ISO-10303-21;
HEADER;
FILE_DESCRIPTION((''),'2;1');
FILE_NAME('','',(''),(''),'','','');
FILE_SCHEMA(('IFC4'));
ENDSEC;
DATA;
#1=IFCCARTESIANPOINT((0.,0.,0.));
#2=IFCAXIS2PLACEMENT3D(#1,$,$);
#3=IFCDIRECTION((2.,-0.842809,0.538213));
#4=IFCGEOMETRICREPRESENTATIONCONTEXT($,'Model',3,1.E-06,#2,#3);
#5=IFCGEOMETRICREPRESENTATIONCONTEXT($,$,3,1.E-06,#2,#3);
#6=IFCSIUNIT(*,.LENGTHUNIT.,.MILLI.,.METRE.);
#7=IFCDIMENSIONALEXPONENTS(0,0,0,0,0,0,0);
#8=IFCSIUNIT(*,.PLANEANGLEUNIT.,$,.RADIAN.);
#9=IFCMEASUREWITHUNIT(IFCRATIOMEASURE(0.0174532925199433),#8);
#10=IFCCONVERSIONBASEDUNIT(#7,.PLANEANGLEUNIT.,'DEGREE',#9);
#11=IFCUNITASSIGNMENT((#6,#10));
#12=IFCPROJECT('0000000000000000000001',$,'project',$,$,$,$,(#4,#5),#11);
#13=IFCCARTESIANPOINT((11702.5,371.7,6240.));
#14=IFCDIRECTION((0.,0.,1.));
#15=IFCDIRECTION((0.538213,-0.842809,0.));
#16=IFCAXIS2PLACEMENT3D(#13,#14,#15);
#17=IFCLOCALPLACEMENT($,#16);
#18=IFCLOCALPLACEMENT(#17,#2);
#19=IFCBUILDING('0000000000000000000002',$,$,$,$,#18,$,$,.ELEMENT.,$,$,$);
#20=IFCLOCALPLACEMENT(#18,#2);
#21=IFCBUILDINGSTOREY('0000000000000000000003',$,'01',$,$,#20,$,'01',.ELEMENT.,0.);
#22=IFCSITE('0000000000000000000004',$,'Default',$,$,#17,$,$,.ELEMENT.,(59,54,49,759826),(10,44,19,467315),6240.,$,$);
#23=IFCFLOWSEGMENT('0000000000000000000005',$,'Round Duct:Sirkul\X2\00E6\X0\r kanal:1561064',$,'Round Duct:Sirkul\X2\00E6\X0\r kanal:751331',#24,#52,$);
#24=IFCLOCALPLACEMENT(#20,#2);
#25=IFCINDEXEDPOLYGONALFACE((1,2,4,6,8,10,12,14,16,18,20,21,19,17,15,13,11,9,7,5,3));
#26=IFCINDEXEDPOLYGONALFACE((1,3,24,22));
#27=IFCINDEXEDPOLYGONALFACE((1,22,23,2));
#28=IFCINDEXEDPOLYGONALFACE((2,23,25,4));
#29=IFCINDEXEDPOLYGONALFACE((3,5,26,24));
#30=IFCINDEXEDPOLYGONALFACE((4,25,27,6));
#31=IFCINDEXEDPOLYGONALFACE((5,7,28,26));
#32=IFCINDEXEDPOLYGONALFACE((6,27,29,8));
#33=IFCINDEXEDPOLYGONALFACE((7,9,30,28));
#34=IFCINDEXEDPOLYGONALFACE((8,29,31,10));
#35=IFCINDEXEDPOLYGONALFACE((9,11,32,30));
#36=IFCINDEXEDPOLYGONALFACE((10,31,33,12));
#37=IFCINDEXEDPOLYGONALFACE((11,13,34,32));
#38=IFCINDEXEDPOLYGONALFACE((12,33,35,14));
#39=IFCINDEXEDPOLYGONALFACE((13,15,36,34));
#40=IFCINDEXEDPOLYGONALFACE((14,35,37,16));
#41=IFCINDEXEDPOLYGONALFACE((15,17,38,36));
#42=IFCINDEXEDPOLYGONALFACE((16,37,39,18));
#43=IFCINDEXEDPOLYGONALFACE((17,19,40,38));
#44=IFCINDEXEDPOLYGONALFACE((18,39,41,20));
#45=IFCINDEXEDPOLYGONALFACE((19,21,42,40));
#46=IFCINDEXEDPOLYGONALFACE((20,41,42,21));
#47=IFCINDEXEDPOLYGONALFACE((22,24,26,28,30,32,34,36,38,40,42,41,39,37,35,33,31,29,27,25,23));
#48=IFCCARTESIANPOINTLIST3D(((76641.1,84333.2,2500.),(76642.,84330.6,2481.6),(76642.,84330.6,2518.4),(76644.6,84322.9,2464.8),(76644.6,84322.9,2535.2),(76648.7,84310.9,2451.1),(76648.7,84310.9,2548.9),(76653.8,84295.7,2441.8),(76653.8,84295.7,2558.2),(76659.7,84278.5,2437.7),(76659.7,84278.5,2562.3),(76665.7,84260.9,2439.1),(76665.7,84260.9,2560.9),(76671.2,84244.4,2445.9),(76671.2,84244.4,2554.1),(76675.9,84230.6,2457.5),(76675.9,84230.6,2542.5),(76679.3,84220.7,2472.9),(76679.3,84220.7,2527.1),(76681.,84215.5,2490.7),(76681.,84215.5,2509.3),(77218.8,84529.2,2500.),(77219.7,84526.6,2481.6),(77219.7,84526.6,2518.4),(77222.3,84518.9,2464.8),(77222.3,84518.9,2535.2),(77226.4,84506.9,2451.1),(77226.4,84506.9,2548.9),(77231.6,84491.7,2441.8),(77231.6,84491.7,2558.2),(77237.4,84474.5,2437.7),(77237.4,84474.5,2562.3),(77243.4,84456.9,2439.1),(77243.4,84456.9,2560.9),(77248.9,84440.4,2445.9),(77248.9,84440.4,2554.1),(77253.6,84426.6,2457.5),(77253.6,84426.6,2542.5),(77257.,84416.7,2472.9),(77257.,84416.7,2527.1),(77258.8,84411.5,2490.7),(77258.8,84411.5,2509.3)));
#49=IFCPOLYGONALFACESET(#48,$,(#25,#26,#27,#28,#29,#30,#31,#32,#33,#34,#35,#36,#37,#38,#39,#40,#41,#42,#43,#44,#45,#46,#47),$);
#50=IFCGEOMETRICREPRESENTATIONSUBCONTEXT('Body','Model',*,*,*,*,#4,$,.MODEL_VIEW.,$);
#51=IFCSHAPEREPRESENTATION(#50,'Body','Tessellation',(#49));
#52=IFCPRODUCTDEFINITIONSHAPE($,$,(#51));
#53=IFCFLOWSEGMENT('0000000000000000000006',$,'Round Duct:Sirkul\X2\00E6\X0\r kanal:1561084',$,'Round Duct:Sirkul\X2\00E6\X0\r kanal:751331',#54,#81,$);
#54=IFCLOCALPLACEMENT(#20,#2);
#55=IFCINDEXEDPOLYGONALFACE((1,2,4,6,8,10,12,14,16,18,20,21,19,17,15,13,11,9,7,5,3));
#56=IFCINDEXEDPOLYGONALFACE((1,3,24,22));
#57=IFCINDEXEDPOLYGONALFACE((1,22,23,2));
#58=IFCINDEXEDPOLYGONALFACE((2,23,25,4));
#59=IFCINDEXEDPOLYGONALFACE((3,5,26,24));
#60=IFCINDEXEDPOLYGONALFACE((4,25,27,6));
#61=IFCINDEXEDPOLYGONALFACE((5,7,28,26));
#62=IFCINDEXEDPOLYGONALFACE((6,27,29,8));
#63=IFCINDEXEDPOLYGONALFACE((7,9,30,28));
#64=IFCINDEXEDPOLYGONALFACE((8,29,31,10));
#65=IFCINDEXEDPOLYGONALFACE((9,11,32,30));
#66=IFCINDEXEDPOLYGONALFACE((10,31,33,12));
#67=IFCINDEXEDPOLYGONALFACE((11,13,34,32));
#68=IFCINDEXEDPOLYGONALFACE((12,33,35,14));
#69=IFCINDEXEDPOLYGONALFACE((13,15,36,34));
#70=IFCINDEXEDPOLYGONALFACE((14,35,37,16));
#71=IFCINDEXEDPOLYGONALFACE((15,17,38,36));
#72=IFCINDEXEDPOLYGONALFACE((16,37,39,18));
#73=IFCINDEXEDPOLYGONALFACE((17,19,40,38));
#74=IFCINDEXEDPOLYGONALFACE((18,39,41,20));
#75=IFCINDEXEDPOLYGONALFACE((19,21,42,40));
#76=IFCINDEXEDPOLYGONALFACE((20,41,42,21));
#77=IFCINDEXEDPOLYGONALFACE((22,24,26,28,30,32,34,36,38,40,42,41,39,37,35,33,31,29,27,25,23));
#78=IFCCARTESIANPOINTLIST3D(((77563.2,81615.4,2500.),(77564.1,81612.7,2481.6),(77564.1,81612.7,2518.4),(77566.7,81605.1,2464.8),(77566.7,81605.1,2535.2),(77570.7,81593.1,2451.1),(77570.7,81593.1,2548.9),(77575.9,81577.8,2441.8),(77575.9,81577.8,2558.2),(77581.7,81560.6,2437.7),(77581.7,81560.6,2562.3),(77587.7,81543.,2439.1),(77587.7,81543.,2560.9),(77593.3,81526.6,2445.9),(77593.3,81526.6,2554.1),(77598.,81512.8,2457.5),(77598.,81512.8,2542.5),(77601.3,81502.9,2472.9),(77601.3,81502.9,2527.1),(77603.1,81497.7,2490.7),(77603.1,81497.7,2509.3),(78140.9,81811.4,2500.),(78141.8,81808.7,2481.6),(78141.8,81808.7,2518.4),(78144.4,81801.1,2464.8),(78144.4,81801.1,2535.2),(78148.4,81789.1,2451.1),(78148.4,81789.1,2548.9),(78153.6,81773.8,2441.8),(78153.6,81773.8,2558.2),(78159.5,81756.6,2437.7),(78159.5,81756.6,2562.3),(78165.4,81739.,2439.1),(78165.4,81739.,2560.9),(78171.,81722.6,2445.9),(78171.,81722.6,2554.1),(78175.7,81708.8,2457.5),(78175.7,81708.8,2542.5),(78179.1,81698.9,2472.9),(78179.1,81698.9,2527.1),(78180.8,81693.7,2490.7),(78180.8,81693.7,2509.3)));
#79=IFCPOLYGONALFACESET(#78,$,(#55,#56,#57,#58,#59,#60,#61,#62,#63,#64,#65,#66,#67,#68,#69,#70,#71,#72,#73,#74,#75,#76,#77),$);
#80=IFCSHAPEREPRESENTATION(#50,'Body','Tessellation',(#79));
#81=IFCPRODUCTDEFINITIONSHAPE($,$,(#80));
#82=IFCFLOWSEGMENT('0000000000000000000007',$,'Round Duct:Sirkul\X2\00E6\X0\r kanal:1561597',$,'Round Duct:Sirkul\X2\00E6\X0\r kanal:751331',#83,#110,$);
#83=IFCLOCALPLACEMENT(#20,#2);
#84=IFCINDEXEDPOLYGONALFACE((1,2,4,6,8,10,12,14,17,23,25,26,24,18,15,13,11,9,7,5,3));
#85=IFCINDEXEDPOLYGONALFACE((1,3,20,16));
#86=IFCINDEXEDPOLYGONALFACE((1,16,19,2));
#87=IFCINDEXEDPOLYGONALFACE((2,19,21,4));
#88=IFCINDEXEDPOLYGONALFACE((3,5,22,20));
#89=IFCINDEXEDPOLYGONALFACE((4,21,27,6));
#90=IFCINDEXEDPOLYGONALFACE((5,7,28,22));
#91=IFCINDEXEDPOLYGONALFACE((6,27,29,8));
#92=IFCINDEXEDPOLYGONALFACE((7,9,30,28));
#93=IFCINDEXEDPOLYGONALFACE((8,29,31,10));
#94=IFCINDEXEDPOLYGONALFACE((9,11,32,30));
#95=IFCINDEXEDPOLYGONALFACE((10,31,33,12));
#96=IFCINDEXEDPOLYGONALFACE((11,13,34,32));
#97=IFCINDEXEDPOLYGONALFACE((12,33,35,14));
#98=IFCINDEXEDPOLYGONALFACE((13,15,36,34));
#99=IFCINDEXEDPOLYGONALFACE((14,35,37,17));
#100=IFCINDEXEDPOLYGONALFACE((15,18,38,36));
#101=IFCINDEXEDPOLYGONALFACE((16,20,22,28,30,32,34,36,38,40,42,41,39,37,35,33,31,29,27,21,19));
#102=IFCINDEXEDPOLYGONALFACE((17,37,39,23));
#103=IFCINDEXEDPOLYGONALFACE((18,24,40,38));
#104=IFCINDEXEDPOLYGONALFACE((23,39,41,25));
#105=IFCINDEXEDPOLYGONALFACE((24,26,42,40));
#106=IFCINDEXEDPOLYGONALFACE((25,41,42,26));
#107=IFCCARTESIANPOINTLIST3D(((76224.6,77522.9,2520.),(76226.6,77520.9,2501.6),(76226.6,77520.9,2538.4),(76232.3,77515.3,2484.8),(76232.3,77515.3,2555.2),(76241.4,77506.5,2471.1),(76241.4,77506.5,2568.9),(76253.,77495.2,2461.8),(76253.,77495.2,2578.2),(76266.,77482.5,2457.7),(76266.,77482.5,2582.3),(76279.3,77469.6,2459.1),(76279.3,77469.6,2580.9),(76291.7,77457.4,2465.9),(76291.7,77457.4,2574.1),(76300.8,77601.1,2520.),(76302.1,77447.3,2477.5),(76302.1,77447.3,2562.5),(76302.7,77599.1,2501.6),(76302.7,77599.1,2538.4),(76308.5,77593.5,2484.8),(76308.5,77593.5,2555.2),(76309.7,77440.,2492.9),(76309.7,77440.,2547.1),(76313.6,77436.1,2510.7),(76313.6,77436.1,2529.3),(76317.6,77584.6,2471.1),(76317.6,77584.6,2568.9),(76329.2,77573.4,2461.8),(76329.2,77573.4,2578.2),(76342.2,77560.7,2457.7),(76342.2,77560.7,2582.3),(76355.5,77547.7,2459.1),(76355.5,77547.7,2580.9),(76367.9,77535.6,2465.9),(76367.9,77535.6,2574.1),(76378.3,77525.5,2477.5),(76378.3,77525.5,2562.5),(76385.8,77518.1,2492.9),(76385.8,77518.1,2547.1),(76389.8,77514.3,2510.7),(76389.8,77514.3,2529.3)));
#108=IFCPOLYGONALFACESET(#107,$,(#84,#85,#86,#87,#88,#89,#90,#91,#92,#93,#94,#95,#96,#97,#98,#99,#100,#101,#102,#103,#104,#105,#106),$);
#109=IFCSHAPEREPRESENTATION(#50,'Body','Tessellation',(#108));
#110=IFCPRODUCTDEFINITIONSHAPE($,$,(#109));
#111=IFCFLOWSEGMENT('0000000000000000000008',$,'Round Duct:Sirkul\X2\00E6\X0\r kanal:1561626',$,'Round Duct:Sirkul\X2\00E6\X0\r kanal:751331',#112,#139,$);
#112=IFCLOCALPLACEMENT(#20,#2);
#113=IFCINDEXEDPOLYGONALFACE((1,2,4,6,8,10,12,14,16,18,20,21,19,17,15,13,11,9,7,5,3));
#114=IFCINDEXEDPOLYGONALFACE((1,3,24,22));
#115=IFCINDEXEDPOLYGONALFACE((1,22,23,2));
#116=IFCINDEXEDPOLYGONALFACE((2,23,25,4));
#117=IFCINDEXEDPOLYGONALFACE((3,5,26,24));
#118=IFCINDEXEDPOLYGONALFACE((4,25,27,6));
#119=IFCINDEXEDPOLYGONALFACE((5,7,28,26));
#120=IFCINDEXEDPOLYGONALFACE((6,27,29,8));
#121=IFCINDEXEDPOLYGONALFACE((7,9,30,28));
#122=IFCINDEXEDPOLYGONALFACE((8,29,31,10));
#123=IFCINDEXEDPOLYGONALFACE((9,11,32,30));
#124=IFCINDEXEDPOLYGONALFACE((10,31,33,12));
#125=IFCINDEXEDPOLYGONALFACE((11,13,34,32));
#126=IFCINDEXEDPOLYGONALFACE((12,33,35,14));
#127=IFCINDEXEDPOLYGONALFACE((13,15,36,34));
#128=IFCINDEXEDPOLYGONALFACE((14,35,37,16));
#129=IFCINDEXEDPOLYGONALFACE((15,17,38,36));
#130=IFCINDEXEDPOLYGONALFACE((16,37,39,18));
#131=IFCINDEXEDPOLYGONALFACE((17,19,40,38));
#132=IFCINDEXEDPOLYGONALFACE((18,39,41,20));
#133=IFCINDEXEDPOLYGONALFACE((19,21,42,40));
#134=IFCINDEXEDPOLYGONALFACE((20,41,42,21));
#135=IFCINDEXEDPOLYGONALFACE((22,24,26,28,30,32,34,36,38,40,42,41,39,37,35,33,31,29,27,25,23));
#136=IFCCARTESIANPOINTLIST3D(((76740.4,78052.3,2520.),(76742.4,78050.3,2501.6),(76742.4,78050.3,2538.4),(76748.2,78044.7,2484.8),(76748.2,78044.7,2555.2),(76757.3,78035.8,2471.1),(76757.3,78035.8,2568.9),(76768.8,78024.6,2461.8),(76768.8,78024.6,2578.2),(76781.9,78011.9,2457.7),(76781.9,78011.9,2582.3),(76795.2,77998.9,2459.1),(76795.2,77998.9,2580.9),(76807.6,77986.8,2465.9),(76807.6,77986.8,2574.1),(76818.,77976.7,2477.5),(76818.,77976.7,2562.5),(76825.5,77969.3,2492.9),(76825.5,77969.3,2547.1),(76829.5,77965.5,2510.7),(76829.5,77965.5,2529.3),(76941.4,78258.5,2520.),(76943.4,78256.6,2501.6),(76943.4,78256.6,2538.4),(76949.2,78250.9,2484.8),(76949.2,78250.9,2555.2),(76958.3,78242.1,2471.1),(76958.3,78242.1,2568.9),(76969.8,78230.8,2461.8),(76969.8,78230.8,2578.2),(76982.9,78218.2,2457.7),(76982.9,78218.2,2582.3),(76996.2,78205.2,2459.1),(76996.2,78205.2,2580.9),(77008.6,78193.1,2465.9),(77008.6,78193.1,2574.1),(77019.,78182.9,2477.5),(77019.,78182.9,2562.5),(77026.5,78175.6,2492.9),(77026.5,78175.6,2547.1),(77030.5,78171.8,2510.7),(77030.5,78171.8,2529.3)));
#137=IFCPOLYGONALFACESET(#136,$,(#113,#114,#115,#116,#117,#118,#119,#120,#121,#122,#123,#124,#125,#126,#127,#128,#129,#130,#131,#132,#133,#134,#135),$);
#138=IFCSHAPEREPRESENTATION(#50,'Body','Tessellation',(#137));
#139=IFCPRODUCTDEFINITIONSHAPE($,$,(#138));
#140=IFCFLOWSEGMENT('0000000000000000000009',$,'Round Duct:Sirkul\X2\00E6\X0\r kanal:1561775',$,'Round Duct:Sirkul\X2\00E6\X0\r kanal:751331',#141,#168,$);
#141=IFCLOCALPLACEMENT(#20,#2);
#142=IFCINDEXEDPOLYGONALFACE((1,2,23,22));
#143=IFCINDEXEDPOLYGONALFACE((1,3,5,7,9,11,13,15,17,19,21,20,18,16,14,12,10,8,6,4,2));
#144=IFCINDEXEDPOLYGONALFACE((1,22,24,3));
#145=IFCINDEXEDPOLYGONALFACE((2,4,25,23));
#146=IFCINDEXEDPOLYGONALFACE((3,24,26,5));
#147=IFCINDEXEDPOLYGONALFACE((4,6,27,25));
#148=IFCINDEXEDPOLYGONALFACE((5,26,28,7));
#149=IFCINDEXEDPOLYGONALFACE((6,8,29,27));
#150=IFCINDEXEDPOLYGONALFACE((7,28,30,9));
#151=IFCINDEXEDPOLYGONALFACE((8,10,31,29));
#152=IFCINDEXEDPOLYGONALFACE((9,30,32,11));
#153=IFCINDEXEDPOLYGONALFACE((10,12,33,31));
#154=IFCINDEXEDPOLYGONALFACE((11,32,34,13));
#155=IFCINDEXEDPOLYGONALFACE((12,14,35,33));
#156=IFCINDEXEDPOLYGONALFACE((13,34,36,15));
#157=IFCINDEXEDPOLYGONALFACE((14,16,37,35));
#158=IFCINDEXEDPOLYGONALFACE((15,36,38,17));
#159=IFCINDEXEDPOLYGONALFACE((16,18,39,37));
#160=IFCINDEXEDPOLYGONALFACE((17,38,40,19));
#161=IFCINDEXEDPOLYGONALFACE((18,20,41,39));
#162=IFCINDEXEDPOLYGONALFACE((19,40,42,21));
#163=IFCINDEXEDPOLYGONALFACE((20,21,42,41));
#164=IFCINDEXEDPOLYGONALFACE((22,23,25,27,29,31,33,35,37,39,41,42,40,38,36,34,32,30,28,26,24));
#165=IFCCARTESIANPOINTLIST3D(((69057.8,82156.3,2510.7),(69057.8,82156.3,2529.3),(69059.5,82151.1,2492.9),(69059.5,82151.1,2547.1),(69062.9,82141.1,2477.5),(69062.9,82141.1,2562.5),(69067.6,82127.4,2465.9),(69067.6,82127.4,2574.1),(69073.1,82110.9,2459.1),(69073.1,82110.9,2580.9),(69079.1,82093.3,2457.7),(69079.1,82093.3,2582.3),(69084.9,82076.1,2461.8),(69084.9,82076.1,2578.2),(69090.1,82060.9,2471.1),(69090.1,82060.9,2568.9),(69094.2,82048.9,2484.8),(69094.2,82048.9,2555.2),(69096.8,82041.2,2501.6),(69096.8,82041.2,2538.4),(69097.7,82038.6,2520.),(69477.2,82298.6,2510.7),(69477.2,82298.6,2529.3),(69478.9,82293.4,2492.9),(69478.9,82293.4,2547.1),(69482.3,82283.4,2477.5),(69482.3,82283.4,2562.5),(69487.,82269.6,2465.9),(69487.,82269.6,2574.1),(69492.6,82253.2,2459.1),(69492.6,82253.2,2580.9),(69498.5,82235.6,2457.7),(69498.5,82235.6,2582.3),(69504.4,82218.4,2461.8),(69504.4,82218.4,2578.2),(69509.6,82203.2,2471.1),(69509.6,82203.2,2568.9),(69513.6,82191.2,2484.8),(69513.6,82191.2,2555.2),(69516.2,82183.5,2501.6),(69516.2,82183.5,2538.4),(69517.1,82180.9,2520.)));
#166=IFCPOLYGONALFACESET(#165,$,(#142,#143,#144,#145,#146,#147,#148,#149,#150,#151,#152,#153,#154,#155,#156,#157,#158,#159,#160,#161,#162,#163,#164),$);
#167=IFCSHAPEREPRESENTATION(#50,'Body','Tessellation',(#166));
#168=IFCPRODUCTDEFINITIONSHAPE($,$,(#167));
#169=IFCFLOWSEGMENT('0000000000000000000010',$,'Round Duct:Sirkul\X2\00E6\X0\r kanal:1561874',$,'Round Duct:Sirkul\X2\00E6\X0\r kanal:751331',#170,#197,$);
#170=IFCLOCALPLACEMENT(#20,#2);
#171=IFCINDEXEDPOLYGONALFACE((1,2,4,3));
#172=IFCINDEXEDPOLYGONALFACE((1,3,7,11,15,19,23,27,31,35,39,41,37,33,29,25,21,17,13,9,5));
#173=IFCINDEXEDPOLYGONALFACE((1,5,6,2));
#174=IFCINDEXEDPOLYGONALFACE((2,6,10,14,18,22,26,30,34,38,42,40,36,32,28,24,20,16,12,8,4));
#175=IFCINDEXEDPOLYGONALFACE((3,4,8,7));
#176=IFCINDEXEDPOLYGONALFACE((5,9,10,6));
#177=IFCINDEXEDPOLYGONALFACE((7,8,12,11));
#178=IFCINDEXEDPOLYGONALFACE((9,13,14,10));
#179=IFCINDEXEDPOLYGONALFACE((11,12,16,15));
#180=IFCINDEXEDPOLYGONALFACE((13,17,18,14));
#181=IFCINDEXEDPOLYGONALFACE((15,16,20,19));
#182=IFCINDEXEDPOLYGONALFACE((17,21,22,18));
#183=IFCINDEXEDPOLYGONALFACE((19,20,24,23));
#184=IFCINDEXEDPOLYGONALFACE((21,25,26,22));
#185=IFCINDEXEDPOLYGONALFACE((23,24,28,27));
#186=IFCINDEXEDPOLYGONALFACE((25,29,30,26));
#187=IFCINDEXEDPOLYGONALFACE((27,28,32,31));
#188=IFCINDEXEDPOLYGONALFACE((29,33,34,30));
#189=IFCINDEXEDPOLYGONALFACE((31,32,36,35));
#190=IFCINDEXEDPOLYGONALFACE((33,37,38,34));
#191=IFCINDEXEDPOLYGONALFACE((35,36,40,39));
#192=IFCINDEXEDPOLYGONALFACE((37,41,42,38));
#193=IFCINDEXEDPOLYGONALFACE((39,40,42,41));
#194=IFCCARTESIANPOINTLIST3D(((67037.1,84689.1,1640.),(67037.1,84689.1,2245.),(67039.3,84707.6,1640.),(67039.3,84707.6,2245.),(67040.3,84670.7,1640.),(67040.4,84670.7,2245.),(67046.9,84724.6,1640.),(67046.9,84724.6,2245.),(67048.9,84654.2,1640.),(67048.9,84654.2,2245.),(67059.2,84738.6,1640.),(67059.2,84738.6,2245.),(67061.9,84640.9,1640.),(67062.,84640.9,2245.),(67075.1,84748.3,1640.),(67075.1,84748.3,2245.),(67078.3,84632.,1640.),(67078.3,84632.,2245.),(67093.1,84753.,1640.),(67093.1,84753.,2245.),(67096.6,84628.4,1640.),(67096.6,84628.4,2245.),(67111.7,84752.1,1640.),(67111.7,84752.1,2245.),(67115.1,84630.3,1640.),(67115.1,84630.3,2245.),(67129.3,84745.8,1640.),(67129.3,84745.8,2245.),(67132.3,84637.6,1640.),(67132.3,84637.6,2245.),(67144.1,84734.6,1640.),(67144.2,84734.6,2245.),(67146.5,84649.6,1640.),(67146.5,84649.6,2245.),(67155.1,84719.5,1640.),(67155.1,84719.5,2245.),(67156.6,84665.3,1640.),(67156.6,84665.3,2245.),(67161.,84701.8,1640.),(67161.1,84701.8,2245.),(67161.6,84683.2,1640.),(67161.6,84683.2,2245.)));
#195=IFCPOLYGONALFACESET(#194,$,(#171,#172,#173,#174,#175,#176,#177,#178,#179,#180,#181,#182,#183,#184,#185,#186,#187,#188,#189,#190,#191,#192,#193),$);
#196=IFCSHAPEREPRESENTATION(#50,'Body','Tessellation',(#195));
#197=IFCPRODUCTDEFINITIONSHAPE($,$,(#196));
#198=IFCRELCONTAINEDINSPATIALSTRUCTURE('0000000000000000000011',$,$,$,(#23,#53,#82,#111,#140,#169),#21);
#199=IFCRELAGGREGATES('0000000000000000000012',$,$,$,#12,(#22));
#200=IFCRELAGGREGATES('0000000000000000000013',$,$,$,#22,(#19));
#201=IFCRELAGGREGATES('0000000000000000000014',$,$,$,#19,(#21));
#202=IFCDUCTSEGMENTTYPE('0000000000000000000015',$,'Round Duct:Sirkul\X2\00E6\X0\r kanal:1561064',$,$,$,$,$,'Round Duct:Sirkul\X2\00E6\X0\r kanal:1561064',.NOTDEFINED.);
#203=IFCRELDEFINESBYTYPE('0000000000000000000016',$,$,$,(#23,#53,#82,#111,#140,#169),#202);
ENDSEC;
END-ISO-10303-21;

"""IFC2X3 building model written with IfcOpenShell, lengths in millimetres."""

from ifc_helpers import new_model, entity, si_unit, converted_unit, direction, frame, origin, origin_2d_with_axis, place, context, subcontext, project, spatial, circle, extrude, type_object, element, save


model = new_model("IFC2X3")

# Units and contexts
model_context = context("Model", 3, precision=1e-06, world=origin(), true_north=direction((2.0, -0.842809, 0.538213)))
context_of_model = context(None, 3, precision=1e-06, world=origin(), true_north=direction((2.0, -0.842809, 0.538213)))
body_context = subcontext(model_context, "Body", "Model", "MODEL_VIEW")
ifc_project = project(units=[si_unit("LENGTHUNIT", "METRE", prefix="MILLI"), converted_unit("PLANEANGLEUNIT", "DEGREE", entity("IfcRatioMeasure", 0.0174532925199433), si_unit("PLANEANGLEUNIT", "RADIAN"), dimensions=[0, 0, 0, 0, 0, 0, 0])], contexts=[model_context, context_of_model])

# Site, building, storey
site_placement = place(None, frame((11702.5, 371.7, 6240.0), z_axis=(0.0, 0.0, 1.0), x_axis=(0.538213, -0.842809, 0.0)))
site = spatial("IfcSite", under=ifc_project, at=site_placement, Name="Default", CompositionType="ELEMENT", RefLatitude=(59, 54, 49, 759826), RefLongitude=(10, 44, 19, 467315), RefElevation=6240.0)
building_placement = place(site_placement, origin())
building = spatial("IfcBuilding", under=site, at=building_placement, CompositionType="ELEMENT")
storey_placement = place(building_placement, origin())
storey = spatial("IfcBuildingStorey", under=building, at=storey_placement, Name="01", LongName="01", CompositionType="ELEMENT", Elevation=0.0)

# Flow segments
duct_segment_type = type_object("IfcDuctSegmentType", Name="Round Duct:Sirkulær kanal:1561064", ElementType="Round Duct:Sirkulær kanal:1561064", PredefinedType="NOTDEFINED")
flow_segment_1_placement = place(storey_placement, origin())
element("IfcFlowSegment", 1, at=flow_segment_1_placement, inside=storey, type_object=duct_segment_type, Name="Round Duct:Sirkulær kanal:1561064", ObjectType="Round Duct:Sirkulær kanal:751331", context=body_context, shape_type="SweptSolid", body=[
    extrude(circle(Radius=62.5, at=origin_2d_with_axis()), frame((76661.2, 84274.0, 2500.0), z_axis=(0.946986, 0.321274, 0.0), x_axis=(-0.321274, 0.946986, 0.0)), (0.0, 0.0, 1.0), 610.1),
])
flow_segment_2_placement = place(storey_placement, origin())
element("IfcFlowSegment", 2, at=flow_segment_2_placement, inside=storey, type_object=duct_segment_type, Name="Round Duct:Sirkulær kanal:1561084", ObjectType="Round Duct:Sirkulær kanal:751331", context=body_context, shape_type="SweptSolid", body=[
    extrude(circle(Radius=62.5, at=origin_2d_with_axis()), frame((77583.2, 81556.2, 2500.0), z_axis=(0.946986, 0.321274, 0.0), x_axis=(-0.321274, 0.946986, 0.0)), (0.0, 0.0, 1.0), 610.1),
])
flow_segment_3_placement = place(storey_placement, origin())
element("IfcFlowSegment", 3, at=flow_segment_3_placement, inside=storey, type_object=duct_segment_type, Name="Round Duct:Sirkulær kanal:1561597", ObjectType="Round Duct:Sirkulær kanal:751331", context=body_context, shape_type="SweptSolid", body=[
    extrude(circle(Radius=62.5, at=origin_2d_with_axis()), frame((76269.3, 77479.3, 2520.0), z_axis=(0.697915, 0.71618, 0.0), x_axis=(-0.71618, 0.697915, 0.0)), (0.0, 0.0, 1.0), 109.2),
])
flow_segment_4_placement = place(storey_placement, origin())
element("IfcFlowSegment", 4, at=flow_segment_4_placement, inside=storey, type_object=duct_segment_type, Name="Round Duct:Sirkulær kanal:1561626", ObjectType="Round Duct:Sirkulær kanal:751331", context=body_context, shape_type="SweptSolid", body=[
    extrude(circle(Radius=62.5, at=origin_2d_with_axis()), frame((76785.2, 78008.6, 2520.0), z_axis=(0.697915, 0.71618, 0.0), x_axis=(-0.71618, 0.697915, 0.0)), (0.0, 0.0, 1.0), 288.0),
])
flow_segment_5_placement = place(storey_placement, origin())
element("IfcFlowSegment", 5, at=flow_segment_5_placement, inside=storey, type_object=duct_segment_type, Name="Round Duct:Sirkulær kanal:1561775", ObjectType="Round Duct:Sirkulær kanal:751331", context=body_context, shape_type="SweptSolid", body=[
    extrude(circle(Radius=62.5, at=origin_2d_with_axis()), frame((69077.6, 82097.8, 2520.0), z_axis=(0.946986, 0.321274, 0.0), x_axis=(0.321274, -0.946986, 0.0)), (0.0, 0.0, 1.0), 442.9),
])
flow_segment_6_placement = place(storey_placement, origin())
element("IfcFlowSegment", 6, at=flow_segment_6_placement, inside=storey, type_object=duct_segment_type, Name="Round Duct:Sirkulær kanal:1561874", ObjectType="Round Duct:Sirkulær kanal:751331", context=body_context, shape_type="SweptSolid", body=[
    extrude(circle(Radius=62.5, at=origin_2d_with_axis()), frame((67099.5, 84690.8, 1640.0), z_axis=(0.000028, 0.000009, 1.0), x_axis=(-0.946968, -0.321326, 0.000029)), (0.0, 0.0, 1.0), 605.0),
])

save(model, "model.ifc")
